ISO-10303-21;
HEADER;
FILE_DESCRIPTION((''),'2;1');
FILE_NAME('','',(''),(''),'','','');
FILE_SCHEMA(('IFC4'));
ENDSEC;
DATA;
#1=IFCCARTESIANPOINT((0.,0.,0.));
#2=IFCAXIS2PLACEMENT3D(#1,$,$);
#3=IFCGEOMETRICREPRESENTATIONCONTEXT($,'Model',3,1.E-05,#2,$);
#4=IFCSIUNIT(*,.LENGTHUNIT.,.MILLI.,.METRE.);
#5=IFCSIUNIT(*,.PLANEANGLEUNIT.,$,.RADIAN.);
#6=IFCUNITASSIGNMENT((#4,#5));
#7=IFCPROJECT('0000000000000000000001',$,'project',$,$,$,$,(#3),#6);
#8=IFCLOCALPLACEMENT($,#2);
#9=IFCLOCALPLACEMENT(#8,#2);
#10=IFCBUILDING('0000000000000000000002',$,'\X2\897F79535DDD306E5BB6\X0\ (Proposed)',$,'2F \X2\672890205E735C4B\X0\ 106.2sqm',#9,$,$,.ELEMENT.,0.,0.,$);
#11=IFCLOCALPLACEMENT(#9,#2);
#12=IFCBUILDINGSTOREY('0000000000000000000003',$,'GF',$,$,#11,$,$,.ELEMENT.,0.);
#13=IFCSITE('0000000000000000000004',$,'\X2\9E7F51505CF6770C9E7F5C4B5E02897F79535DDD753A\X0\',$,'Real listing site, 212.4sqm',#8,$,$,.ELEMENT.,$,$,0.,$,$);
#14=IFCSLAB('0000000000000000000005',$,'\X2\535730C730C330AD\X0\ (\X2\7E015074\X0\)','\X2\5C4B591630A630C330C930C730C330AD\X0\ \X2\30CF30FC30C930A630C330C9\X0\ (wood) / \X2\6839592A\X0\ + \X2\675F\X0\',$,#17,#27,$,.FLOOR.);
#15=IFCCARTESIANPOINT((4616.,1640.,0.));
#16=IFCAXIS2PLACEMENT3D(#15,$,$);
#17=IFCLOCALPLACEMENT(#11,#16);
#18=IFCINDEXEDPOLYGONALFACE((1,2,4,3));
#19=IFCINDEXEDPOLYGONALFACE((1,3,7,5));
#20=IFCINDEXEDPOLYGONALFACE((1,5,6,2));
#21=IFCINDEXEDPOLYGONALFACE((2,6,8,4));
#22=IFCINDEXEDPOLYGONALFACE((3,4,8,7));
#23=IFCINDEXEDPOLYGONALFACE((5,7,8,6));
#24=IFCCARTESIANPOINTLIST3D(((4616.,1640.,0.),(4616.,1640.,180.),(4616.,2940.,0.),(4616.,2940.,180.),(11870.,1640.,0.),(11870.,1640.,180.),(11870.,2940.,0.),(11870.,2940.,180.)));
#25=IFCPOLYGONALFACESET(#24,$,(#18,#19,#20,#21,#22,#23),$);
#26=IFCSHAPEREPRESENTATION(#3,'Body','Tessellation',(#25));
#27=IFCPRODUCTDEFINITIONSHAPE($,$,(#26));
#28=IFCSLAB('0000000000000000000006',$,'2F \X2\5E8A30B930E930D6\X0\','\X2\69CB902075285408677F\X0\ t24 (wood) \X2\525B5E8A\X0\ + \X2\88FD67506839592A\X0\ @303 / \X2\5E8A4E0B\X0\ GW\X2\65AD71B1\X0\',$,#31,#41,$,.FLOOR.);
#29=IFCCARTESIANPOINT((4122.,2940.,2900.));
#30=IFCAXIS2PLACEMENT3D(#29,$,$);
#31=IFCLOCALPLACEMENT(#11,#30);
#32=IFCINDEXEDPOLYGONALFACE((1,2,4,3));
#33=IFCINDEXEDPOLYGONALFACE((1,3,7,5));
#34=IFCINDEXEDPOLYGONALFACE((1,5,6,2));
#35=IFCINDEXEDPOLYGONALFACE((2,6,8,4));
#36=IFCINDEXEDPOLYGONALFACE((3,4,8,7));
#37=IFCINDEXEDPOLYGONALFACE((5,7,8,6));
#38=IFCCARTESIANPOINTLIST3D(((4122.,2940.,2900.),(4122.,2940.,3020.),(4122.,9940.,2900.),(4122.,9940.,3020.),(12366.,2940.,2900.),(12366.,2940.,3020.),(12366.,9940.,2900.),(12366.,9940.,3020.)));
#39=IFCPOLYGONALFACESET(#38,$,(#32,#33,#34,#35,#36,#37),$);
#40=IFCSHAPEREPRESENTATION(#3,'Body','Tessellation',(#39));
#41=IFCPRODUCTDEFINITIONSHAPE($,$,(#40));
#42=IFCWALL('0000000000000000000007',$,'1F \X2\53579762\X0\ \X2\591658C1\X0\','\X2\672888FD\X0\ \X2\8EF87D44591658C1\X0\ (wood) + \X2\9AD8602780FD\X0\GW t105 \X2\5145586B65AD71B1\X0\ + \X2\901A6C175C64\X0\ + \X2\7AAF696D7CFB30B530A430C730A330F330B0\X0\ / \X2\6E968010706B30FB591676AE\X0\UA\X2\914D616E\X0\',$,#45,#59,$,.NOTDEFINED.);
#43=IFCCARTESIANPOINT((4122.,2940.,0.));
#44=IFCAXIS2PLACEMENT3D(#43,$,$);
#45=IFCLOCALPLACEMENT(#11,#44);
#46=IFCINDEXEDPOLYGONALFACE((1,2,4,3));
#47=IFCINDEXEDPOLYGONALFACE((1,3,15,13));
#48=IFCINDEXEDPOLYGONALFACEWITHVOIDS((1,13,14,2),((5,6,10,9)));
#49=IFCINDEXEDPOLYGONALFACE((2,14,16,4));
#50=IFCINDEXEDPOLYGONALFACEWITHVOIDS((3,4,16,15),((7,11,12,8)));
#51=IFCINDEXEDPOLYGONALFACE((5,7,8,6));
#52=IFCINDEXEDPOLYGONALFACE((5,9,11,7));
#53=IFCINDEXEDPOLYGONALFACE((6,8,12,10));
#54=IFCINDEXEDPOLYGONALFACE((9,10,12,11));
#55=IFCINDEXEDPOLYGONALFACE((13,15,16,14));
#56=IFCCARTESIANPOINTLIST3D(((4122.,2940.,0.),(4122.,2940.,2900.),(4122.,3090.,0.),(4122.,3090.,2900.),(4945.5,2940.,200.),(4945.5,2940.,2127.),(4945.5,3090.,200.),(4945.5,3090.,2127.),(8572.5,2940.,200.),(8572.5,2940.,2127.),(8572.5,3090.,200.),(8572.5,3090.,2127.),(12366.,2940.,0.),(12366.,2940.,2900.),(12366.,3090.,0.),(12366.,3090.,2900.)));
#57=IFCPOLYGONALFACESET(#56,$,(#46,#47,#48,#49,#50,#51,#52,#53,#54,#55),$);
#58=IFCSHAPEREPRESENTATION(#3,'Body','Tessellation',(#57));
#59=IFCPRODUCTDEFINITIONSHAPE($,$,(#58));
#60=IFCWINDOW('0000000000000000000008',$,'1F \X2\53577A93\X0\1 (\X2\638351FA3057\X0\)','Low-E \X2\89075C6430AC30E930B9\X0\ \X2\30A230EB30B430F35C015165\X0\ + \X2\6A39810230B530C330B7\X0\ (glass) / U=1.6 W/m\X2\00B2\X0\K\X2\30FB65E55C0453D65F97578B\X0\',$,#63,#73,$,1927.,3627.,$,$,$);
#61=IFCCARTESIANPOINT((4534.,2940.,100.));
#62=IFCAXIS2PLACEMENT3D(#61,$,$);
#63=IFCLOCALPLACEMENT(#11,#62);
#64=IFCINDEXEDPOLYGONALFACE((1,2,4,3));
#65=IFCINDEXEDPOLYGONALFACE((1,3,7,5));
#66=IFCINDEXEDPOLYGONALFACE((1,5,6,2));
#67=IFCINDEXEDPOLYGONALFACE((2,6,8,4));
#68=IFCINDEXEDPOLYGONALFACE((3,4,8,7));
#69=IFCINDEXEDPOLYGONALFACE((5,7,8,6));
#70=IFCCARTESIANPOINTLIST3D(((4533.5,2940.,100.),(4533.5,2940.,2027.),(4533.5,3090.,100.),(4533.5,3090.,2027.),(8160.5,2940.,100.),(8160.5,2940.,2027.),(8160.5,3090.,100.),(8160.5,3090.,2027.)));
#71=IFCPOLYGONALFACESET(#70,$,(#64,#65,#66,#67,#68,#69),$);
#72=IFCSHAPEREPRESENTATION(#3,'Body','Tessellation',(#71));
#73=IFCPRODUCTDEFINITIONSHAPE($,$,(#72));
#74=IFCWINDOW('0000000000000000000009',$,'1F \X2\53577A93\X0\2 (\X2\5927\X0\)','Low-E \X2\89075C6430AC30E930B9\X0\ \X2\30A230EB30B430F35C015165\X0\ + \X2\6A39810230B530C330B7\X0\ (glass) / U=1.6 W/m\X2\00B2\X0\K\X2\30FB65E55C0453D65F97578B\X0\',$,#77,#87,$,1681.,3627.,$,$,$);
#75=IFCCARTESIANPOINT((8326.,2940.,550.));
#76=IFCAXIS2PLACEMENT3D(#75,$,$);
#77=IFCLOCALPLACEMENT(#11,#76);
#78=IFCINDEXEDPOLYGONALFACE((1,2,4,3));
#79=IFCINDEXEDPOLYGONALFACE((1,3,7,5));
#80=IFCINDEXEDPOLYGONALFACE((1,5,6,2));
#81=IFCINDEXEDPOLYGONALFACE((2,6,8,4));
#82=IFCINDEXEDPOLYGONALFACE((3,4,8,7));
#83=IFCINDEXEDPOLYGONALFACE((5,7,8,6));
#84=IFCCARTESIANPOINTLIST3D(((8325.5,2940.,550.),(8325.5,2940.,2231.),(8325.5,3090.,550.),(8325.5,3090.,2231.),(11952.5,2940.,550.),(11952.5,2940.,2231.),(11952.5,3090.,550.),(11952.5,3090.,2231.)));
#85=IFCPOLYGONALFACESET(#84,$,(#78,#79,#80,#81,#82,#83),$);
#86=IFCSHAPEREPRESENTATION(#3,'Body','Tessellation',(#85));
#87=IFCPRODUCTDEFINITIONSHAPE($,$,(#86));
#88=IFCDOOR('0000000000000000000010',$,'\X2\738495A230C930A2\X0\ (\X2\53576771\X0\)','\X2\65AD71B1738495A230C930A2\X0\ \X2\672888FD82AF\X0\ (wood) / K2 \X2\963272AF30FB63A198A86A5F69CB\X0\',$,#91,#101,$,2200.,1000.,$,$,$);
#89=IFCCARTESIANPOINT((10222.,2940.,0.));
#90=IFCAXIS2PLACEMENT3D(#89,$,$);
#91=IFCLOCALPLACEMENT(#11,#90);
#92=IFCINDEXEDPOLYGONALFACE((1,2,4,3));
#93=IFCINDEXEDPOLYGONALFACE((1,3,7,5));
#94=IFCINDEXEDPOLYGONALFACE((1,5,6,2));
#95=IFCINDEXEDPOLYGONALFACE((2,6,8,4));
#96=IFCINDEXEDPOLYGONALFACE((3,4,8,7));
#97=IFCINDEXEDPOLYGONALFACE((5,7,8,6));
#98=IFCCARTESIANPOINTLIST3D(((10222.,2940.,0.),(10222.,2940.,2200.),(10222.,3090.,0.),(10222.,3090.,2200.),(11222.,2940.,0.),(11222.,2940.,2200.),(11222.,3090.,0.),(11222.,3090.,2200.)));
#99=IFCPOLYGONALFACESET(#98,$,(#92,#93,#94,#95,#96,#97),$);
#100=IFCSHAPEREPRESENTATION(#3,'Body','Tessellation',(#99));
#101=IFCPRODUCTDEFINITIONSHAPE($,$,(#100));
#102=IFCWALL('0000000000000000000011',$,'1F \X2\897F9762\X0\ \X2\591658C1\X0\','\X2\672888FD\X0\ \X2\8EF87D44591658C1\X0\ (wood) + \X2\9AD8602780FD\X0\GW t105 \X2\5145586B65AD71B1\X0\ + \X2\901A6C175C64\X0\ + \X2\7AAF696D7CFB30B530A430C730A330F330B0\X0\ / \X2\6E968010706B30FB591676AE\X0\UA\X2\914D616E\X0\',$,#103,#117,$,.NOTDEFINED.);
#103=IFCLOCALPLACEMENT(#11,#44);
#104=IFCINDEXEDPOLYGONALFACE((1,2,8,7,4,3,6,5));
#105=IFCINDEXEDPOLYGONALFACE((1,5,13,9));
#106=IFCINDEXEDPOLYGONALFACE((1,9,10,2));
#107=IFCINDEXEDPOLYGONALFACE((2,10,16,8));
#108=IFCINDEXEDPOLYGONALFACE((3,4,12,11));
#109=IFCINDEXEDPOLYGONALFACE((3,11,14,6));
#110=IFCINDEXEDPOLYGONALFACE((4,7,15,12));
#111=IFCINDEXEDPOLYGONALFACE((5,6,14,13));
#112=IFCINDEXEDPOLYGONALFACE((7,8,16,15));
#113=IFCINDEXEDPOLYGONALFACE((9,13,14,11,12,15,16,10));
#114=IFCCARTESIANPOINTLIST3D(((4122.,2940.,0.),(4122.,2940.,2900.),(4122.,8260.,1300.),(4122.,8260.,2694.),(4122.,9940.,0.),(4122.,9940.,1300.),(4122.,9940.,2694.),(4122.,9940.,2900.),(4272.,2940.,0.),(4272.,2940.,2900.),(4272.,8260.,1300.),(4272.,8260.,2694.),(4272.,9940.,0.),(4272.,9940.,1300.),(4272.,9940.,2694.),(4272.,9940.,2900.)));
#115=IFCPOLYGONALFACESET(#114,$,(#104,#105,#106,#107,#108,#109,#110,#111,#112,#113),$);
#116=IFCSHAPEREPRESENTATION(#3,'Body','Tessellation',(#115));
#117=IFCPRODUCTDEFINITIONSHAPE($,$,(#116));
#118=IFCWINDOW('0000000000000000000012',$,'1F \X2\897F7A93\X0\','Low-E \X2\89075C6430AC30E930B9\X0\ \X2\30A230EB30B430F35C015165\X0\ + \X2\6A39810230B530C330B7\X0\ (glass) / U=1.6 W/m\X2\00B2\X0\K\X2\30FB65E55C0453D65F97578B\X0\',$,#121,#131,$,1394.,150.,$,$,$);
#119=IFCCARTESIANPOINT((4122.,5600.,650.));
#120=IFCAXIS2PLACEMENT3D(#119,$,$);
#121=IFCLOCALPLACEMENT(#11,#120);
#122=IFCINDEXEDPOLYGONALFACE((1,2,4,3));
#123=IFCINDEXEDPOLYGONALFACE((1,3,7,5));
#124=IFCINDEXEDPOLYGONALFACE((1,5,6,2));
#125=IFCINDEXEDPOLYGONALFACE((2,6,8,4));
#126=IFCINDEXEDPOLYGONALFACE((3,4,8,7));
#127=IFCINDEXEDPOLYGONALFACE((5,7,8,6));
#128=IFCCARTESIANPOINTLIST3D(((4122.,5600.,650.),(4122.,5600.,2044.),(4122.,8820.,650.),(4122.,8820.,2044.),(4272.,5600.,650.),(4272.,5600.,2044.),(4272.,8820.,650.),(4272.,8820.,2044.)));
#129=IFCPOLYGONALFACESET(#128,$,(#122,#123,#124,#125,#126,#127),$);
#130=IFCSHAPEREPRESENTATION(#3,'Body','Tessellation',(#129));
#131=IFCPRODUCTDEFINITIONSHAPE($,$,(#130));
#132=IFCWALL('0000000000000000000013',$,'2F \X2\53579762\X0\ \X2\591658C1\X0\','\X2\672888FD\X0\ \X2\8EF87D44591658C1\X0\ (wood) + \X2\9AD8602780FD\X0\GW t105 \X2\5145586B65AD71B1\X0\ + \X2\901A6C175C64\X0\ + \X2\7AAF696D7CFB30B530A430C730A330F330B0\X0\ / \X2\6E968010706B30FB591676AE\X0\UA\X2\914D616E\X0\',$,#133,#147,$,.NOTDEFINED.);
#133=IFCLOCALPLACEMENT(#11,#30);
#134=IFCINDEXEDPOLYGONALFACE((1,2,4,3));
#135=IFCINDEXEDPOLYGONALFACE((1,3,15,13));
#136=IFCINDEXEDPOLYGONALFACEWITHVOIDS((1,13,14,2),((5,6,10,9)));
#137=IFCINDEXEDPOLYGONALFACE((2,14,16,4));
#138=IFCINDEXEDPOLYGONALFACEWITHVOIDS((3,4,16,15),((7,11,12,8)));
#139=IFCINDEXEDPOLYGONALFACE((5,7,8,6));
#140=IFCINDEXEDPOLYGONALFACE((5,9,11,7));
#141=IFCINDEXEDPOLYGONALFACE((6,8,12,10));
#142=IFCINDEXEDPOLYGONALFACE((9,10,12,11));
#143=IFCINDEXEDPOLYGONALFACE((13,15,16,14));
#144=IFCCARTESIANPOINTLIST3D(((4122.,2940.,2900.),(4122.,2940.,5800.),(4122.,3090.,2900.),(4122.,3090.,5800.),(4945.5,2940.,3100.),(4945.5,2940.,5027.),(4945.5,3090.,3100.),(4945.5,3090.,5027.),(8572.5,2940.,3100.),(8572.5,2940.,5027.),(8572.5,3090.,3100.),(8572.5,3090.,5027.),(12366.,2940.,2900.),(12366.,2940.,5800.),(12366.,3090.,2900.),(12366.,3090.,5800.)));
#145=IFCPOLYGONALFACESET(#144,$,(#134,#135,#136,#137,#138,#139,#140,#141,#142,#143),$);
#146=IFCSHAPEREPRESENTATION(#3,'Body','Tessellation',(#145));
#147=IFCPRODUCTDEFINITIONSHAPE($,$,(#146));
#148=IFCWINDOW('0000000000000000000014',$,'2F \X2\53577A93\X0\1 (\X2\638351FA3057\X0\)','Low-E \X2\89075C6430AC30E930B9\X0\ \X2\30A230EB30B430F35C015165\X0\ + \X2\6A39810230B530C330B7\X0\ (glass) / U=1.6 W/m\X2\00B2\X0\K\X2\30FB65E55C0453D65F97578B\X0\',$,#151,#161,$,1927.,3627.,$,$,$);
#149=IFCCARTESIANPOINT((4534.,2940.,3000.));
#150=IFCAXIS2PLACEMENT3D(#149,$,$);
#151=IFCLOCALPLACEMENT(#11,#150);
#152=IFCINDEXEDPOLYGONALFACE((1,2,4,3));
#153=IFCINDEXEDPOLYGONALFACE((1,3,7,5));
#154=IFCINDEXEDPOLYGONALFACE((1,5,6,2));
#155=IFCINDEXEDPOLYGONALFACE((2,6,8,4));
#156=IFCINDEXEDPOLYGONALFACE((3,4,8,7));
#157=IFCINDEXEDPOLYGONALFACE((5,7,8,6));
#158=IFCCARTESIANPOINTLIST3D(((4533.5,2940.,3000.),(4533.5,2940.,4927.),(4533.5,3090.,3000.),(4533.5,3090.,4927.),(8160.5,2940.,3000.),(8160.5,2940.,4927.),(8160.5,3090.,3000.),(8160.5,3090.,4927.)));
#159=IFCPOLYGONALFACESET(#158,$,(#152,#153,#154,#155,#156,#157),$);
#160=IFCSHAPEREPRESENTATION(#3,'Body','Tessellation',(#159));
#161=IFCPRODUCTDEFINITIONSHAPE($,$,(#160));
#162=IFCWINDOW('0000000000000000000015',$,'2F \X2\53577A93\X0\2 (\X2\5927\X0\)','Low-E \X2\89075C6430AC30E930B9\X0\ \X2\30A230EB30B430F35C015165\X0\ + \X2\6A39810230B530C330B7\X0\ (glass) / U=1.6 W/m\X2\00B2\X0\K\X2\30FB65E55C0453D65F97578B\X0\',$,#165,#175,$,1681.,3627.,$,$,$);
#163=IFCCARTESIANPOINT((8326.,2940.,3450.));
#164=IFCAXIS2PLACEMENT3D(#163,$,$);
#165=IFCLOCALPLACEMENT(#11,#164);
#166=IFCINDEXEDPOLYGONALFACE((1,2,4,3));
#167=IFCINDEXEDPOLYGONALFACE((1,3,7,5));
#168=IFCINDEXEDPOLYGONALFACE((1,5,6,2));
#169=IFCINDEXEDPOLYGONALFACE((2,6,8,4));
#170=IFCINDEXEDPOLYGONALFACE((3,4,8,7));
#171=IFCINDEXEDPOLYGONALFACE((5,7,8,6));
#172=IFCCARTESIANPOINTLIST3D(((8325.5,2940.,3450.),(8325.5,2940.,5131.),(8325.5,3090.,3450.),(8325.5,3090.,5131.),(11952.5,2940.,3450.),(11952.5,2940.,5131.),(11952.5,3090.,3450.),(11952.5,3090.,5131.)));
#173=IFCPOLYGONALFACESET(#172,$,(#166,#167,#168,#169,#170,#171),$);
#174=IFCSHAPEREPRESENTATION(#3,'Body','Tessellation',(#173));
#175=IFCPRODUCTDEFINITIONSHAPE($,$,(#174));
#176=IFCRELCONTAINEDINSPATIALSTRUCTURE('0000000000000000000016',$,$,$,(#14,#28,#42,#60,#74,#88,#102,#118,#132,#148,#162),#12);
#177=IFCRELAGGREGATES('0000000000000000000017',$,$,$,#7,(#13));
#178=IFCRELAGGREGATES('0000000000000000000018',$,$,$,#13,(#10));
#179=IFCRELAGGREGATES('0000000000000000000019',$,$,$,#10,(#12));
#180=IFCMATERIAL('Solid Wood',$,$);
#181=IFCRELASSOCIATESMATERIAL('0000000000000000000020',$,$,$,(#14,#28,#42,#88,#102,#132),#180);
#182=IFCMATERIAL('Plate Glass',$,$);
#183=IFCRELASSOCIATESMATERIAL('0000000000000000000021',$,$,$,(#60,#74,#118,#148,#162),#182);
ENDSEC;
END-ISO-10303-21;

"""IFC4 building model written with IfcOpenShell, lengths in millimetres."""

from ifc_helpers import new_model, si_unit, frame, frame_2d, origin, place, context, project, spatial, rectangle, extrude, material, element, fill, save


model = new_model("IFC4")

# Units and contexts
model_context = context("Model", 3, precision=1e-05, world=origin())
ifc_project = project(units=[si_unit("LENGTHUNIT", "METRE", prefix="MILLI"), si_unit("PLANEANGLEUNIT", "RADIAN")], contexts=[model_context])

# Site, building, storey
site_placement = place(None, origin())
site = spatial("IfcSite", under=ifc_project, at=site_placement, Name="鹿児島県鹿屋市西祓川町", ObjectType="Real listing site, 212.4sqm", CompositionType="ELEMENT", RefElevation=0.0)
building_placement = place(site_placement, origin())
building = spatial("IfcBuilding", under=site, at=building_placement, Name="西祓川の家 (Proposed)", ObjectType="2F 木造平屋 106.2sqm", CompositionType="ELEMENT", ElevationOfRefHeight=0.0, ElevationOfTerrain=0.0)
storey_placement = place(building_placement, origin())
storey = spatial("IfcBuildingStorey", under=building, at=storey_placement, Name="GF", CompositionType="ELEMENT", Elevation=0.0)

# Slabs
ifc_material_1 = material(Name="Solid Wood")
slab_1_placement = place(storey_placement, frame((4616.0, 1640.0, 0.0)))
element("IfcSlab", 1, at=slab_1_placement, inside=storey, material=ifc_material_1, Name="南デッキ (縁側)", Description="屋外ウッドデッキ ハードウッド (wood) / 根太 + 束", PredefinedType="FLOOR", context=model_context, shape_type="SweptSolid", body=[
    extrude(rectangle(XDim=7254.0, YDim=1300.0, at=frame_2d((3627.0, 650.0))), frame((4616.0, 1640.0, 0.0)), (0.0, 0.0, 1.0), 180.0),
])
slab_2_placement = place(storey_placement, frame((4122.0, 2940.0, 2900.0)))
element("IfcSlab", 2, at=slab_2_placement, inside=storey, material=ifc_material_1, Name="2F 床スラブ", Description="構造用合板 t24 (wood) 剛床 + 製材根太 @303 / 床下 GW断熱", PredefinedType="FLOOR", context=model_context, shape_type="SweptSolid", body=[
    extrude(rectangle(XDim=8244.0, YDim=7000.0, at=frame_2d((4122.0, 3500.0))), frame((4122.0, 2940.0, 2900.0)), (0.0, 0.0, 1.0), 120.0),
])

# Wall, openings, windows, door
wall_1_placement = place(storey_placement, frame((4122.0, 2940.0, 0.0)))
wall_1 = element("IfcWall", 3, at=wall_1_placement, inside=storey, material=ifc_material_1, Name="1F 南面 外壁", Description="木製 軸組外壁 (wood) + 高性能GW t105 充填断熱 + 通気層 + 窯業系サイディング / 準耐火・外皮UA配慮", PredefinedType="NOTDEFINED", context=model_context, shape_type="SweptSolid", body=[
    extrude(rectangle(XDim=8244.0, YDim=150.0, at=frame_2d((4122.0, 75.0))), frame((4122.0, 2940.0, 0.0)), (0.0, 0.0, 1.0), 2900.0),
])
opening_1_placement = place(storey_placement, frame((4534.0, 2940.0, 100.0)))
opening_1 = element("IfcOpeningElement", 4, at=opening_1_placement, cuts=wall_1, PredefinedType="NOTDEFINED", context=model_context, shape_type="SweptSolid", body=[
    extrude(rectangle(XDim=3627.0, YDim=150.0, at=frame_2d((1813.0, 75.0))), frame((4534.0, 2940.0, 100.0)), (0.0, 0.0, 1.0), 1927.0),
])
opening_2_placement = place(storey_placement, frame((8326.0, 2940.0, 550.0)))
opening_2 = element("IfcOpeningElement", 5, at=opening_2_placement, cuts=wall_1, PredefinedType="NOTDEFINED", context=model_context, shape_type="SweptSolid", body=[
    extrude(rectangle(XDim=3627.0, YDim=150.0, at=frame_2d((1813.0, 75.0))), frame((8326.0, 2940.0, 550.0)), (0.0, 0.0, 1.0), 1681.0),
])
opening_3_placement = place(storey_placement, frame((10222.0, 2940.0, 0.0)))
opening_3 = element("IfcOpeningElement", 6, at=opening_3_placement, cuts=wall_1, PredefinedType="NOTDEFINED", context=model_context, shape_type="SweptSolid", body=[
    extrude(rectangle(XDim=1000.0, YDim=150.0, at=frame_2d((500.0, 75.0))), frame((10222.0, 2940.0, 0.0)), (0.0, 0.0, 1.0), 2200.0),
])
ifc_material_2 = material(Name="Plate Glass")
window_1_placement = place(storey_placement, frame((4534.0, 2940.0, 100.0)))
window_1 = element("IfcWindow", 7, at=window_1_placement, inside=storey, material=ifc_material_2, Name="1F 南窓1 (掃出し)", Description="Low-E 複層ガラス アルゴン封入 + 樹脂サッシ (glass) / U=1.6 W/m²K・日射取得型", OverallHeight=1927.0, OverallWidth=3627.0, context=model_context, shape_type="SweptSolid", body=[
    extrude(rectangle(XDim=3627.0, YDim=150.0, at=frame_2d((1813.0, 75.0))), frame((4534.0, 2940.0, 100.0)), (0.0, 0.0, 1.0), 1927.0),
])
fill(opening_1, window_1)
window_2_placement = place(storey_placement, frame((8326.0, 2940.0, 550.0)))
window_2 = element("IfcWindow", 8, at=window_2_placement, inside=storey, material=ifc_material_2, Name="1F 南窓2 (大)", Description="Low-E 複層ガラス アルゴン封入 + 樹脂サッシ (glass) / U=1.6 W/m²K・日射取得型", OverallHeight=1681.0, OverallWidth=3627.0, context=model_context, shape_type="SweptSolid", body=[
    extrude(rectangle(XDim=3627.0, YDim=150.0, at=frame_2d((1813.0, 75.0))), frame((8326.0, 2940.0, 550.0)), (0.0, 0.0, 1.0), 1681.0),
])
fill(opening_2, window_2)
door_placement = place(storey_placement, frame((10222.0, 2940.0, 0.0)))
door = element("IfcDoor", 9, at=door_placement, inside=storey, material=ifc_material_1, Name="玄関ドア (南東)", Description="断熱玄関ドア 木製芯 (wood) / K2 防犯・採風機構", OverallHeight=2200.0, OverallWidth=1000.0, context=model_context, shape_type="SweptSolid", body=[
    extrude(rectangle(XDim=1000.0, YDim=150.0, at=frame_2d((500.0, 75.0))), frame((10222.0, 2940.0, 0.0)), (0.0, 0.0, 1.0), 2200.0),
])
fill(opening_3, door)

# Wall, opening, window
wall_2_placement = place(storey_placement, frame((4122.0, 2940.0, 0.0)))
wall_2 = element("IfcWall", 10, at=wall_2_placement, inside=storey, material=ifc_material_1, Name="1F 西面 外壁", Description="木製 軸組外壁 (wood) + 高性能GW t105 充填断熱 + 通気層 + 窯業系サイディング / 準耐火・外皮UA配慮", PredefinedType="NOTDEFINED", context=model_context, shape_type="SweptSolid", body=[
    extrude(rectangle(XDim=150.0, YDim=7000.0, at=frame_2d((75.0, 3500.0))), frame((4122.0, 2940.0, 0.0)), (0.0, 0.0, 1.0), 2900.0),
])
opening_4_placement = place(storey_placement, frame((4122.0, 5600.0, 650.0)))
opening_4 = element("IfcOpeningElement", 11, at=opening_4_placement, cuts=wall_2, PredefinedType="NOTDEFINED", context=model_context, shape_type="SweptSolid", body=[
    extrude(rectangle(XDim=150.0, YDim=3220.0, at=frame_2d((75.0, 1610.0))), frame((4122.0, 5600.0, 650.0)), (0.0, 0.0, 1.0), 1394.0),
])
window_3_placement = place(storey_placement, frame((4122.0, 5600.0, 650.0)))
window_3 = element("IfcWindow", 12, at=window_3_placement, inside=storey, material=ifc_material_2, Name="1F 西窓", Description="Low-E 複層ガラス アルゴン封入 + 樹脂サッシ (glass) / U=1.6 W/m²K・日射取得型", OverallHeight=1394.0, OverallWidth=150.0, context=model_context, shape_type="SweptSolid", body=[
    extrude(rectangle(XDim=150.0, YDim=3220.0, at=frame_2d((75.0, 1610.0))), frame((4122.0, 5600.0, 650.0)), (0.0, 0.0, 1.0), 1394.0),
])
fill(opening_4, window_3)

# Wall, openings, windows
wall_3_placement = place(storey_placement, frame((4122.0, 2940.0, 2900.0)))
wall_3 = element("IfcWall", 13, at=wall_3_placement, inside=storey, material=ifc_material_1, Name="2F 南面 外壁", Description="木製 軸組外壁 (wood) + 高性能GW t105 充填断熱 + 通気層 + 窯業系サイディング / 準耐火・外皮UA配慮", PredefinedType="NOTDEFINED", context=model_context, shape_type="SweptSolid", body=[
    extrude(rectangle(XDim=8244.0, YDim=150.0, at=frame_2d((4122.0, 75.0))), frame((4122.0, 2940.0, 2900.0)), (0.0, 0.0, 1.0), 2900.0),
])
opening_5_placement = place(storey_placement, frame((4534.0, 2940.0, 3000.0)))
opening_5 = element("IfcOpeningElement", 14, at=opening_5_placement, cuts=wall_3, PredefinedType="NOTDEFINED", context=model_context, shape_type="SweptSolid", body=[
    extrude(rectangle(XDim=3627.0, YDim=150.0, at=frame_2d((1813.0, 75.0))), frame((4534.0, 2940.0, 3000.0)), (0.0, 0.0, 1.0), 1927.0),
])
opening_6_placement = place(storey_placement, frame((8326.0, 2940.0, 3450.0)))
opening_6 = element("IfcOpeningElement", 15, at=opening_6_placement, cuts=wall_3, PredefinedType="NOTDEFINED", context=model_context, shape_type="SweptSolid", body=[
    extrude(rectangle(XDim=3627.0, YDim=150.0, at=frame_2d((1813.0, 75.0))), frame((8326.0, 2940.0, 3450.0)), (0.0, 0.0, 1.0), 1681.0),
])
window_4_placement = place(storey_placement, frame((4534.0, 2940.0, 3000.0)))
window_4 = element("IfcWindow", 16, at=window_4_placement, inside=storey, material=ifc_material_2, Name="2F 南窓1 (掃出し)", Description="Low-E 複層ガラス アルゴン封入 + 樹脂サッシ (glass) / U=1.6 W/m²K・日射取得型", OverallHeight=1927.0, OverallWidth=3627.0, context=model_context, shape_type="SweptSolid", body=[
    extrude(rectangle(XDim=3627.0, YDim=150.0, at=frame_2d((1813.0, 75.0))), frame((4534.0, 2940.0, 3000.0)), (0.0, 0.0, 1.0), 1927.0),
])
fill(opening_5, window_4)
window_5_placement = place(storey_placement, frame((8326.0, 2940.0, 3450.0)))
window_5 = element("IfcWindow", 17, at=window_5_placement, inside=storey, material=ifc_material_2, Name="2F 南窓2 (大)", Description="Low-E 複層ガラス アルゴン封入 + 樹脂サッシ (glass) / U=1.6 W/m²K・日射取得型", OverallHeight=1681.0, OverallWidth=3627.0, context=model_context, shape_type="SweptSolid", body=[
    extrude(rectangle(XDim=3627.0, YDim=150.0, at=frame_2d((1813.0, 75.0))), frame((8326.0, 2940.0, 3450.0)), (0.0, 0.0, 1.0), 1681.0),
])
fill(opening_6, window_5)

save(model, "model.ifc")
